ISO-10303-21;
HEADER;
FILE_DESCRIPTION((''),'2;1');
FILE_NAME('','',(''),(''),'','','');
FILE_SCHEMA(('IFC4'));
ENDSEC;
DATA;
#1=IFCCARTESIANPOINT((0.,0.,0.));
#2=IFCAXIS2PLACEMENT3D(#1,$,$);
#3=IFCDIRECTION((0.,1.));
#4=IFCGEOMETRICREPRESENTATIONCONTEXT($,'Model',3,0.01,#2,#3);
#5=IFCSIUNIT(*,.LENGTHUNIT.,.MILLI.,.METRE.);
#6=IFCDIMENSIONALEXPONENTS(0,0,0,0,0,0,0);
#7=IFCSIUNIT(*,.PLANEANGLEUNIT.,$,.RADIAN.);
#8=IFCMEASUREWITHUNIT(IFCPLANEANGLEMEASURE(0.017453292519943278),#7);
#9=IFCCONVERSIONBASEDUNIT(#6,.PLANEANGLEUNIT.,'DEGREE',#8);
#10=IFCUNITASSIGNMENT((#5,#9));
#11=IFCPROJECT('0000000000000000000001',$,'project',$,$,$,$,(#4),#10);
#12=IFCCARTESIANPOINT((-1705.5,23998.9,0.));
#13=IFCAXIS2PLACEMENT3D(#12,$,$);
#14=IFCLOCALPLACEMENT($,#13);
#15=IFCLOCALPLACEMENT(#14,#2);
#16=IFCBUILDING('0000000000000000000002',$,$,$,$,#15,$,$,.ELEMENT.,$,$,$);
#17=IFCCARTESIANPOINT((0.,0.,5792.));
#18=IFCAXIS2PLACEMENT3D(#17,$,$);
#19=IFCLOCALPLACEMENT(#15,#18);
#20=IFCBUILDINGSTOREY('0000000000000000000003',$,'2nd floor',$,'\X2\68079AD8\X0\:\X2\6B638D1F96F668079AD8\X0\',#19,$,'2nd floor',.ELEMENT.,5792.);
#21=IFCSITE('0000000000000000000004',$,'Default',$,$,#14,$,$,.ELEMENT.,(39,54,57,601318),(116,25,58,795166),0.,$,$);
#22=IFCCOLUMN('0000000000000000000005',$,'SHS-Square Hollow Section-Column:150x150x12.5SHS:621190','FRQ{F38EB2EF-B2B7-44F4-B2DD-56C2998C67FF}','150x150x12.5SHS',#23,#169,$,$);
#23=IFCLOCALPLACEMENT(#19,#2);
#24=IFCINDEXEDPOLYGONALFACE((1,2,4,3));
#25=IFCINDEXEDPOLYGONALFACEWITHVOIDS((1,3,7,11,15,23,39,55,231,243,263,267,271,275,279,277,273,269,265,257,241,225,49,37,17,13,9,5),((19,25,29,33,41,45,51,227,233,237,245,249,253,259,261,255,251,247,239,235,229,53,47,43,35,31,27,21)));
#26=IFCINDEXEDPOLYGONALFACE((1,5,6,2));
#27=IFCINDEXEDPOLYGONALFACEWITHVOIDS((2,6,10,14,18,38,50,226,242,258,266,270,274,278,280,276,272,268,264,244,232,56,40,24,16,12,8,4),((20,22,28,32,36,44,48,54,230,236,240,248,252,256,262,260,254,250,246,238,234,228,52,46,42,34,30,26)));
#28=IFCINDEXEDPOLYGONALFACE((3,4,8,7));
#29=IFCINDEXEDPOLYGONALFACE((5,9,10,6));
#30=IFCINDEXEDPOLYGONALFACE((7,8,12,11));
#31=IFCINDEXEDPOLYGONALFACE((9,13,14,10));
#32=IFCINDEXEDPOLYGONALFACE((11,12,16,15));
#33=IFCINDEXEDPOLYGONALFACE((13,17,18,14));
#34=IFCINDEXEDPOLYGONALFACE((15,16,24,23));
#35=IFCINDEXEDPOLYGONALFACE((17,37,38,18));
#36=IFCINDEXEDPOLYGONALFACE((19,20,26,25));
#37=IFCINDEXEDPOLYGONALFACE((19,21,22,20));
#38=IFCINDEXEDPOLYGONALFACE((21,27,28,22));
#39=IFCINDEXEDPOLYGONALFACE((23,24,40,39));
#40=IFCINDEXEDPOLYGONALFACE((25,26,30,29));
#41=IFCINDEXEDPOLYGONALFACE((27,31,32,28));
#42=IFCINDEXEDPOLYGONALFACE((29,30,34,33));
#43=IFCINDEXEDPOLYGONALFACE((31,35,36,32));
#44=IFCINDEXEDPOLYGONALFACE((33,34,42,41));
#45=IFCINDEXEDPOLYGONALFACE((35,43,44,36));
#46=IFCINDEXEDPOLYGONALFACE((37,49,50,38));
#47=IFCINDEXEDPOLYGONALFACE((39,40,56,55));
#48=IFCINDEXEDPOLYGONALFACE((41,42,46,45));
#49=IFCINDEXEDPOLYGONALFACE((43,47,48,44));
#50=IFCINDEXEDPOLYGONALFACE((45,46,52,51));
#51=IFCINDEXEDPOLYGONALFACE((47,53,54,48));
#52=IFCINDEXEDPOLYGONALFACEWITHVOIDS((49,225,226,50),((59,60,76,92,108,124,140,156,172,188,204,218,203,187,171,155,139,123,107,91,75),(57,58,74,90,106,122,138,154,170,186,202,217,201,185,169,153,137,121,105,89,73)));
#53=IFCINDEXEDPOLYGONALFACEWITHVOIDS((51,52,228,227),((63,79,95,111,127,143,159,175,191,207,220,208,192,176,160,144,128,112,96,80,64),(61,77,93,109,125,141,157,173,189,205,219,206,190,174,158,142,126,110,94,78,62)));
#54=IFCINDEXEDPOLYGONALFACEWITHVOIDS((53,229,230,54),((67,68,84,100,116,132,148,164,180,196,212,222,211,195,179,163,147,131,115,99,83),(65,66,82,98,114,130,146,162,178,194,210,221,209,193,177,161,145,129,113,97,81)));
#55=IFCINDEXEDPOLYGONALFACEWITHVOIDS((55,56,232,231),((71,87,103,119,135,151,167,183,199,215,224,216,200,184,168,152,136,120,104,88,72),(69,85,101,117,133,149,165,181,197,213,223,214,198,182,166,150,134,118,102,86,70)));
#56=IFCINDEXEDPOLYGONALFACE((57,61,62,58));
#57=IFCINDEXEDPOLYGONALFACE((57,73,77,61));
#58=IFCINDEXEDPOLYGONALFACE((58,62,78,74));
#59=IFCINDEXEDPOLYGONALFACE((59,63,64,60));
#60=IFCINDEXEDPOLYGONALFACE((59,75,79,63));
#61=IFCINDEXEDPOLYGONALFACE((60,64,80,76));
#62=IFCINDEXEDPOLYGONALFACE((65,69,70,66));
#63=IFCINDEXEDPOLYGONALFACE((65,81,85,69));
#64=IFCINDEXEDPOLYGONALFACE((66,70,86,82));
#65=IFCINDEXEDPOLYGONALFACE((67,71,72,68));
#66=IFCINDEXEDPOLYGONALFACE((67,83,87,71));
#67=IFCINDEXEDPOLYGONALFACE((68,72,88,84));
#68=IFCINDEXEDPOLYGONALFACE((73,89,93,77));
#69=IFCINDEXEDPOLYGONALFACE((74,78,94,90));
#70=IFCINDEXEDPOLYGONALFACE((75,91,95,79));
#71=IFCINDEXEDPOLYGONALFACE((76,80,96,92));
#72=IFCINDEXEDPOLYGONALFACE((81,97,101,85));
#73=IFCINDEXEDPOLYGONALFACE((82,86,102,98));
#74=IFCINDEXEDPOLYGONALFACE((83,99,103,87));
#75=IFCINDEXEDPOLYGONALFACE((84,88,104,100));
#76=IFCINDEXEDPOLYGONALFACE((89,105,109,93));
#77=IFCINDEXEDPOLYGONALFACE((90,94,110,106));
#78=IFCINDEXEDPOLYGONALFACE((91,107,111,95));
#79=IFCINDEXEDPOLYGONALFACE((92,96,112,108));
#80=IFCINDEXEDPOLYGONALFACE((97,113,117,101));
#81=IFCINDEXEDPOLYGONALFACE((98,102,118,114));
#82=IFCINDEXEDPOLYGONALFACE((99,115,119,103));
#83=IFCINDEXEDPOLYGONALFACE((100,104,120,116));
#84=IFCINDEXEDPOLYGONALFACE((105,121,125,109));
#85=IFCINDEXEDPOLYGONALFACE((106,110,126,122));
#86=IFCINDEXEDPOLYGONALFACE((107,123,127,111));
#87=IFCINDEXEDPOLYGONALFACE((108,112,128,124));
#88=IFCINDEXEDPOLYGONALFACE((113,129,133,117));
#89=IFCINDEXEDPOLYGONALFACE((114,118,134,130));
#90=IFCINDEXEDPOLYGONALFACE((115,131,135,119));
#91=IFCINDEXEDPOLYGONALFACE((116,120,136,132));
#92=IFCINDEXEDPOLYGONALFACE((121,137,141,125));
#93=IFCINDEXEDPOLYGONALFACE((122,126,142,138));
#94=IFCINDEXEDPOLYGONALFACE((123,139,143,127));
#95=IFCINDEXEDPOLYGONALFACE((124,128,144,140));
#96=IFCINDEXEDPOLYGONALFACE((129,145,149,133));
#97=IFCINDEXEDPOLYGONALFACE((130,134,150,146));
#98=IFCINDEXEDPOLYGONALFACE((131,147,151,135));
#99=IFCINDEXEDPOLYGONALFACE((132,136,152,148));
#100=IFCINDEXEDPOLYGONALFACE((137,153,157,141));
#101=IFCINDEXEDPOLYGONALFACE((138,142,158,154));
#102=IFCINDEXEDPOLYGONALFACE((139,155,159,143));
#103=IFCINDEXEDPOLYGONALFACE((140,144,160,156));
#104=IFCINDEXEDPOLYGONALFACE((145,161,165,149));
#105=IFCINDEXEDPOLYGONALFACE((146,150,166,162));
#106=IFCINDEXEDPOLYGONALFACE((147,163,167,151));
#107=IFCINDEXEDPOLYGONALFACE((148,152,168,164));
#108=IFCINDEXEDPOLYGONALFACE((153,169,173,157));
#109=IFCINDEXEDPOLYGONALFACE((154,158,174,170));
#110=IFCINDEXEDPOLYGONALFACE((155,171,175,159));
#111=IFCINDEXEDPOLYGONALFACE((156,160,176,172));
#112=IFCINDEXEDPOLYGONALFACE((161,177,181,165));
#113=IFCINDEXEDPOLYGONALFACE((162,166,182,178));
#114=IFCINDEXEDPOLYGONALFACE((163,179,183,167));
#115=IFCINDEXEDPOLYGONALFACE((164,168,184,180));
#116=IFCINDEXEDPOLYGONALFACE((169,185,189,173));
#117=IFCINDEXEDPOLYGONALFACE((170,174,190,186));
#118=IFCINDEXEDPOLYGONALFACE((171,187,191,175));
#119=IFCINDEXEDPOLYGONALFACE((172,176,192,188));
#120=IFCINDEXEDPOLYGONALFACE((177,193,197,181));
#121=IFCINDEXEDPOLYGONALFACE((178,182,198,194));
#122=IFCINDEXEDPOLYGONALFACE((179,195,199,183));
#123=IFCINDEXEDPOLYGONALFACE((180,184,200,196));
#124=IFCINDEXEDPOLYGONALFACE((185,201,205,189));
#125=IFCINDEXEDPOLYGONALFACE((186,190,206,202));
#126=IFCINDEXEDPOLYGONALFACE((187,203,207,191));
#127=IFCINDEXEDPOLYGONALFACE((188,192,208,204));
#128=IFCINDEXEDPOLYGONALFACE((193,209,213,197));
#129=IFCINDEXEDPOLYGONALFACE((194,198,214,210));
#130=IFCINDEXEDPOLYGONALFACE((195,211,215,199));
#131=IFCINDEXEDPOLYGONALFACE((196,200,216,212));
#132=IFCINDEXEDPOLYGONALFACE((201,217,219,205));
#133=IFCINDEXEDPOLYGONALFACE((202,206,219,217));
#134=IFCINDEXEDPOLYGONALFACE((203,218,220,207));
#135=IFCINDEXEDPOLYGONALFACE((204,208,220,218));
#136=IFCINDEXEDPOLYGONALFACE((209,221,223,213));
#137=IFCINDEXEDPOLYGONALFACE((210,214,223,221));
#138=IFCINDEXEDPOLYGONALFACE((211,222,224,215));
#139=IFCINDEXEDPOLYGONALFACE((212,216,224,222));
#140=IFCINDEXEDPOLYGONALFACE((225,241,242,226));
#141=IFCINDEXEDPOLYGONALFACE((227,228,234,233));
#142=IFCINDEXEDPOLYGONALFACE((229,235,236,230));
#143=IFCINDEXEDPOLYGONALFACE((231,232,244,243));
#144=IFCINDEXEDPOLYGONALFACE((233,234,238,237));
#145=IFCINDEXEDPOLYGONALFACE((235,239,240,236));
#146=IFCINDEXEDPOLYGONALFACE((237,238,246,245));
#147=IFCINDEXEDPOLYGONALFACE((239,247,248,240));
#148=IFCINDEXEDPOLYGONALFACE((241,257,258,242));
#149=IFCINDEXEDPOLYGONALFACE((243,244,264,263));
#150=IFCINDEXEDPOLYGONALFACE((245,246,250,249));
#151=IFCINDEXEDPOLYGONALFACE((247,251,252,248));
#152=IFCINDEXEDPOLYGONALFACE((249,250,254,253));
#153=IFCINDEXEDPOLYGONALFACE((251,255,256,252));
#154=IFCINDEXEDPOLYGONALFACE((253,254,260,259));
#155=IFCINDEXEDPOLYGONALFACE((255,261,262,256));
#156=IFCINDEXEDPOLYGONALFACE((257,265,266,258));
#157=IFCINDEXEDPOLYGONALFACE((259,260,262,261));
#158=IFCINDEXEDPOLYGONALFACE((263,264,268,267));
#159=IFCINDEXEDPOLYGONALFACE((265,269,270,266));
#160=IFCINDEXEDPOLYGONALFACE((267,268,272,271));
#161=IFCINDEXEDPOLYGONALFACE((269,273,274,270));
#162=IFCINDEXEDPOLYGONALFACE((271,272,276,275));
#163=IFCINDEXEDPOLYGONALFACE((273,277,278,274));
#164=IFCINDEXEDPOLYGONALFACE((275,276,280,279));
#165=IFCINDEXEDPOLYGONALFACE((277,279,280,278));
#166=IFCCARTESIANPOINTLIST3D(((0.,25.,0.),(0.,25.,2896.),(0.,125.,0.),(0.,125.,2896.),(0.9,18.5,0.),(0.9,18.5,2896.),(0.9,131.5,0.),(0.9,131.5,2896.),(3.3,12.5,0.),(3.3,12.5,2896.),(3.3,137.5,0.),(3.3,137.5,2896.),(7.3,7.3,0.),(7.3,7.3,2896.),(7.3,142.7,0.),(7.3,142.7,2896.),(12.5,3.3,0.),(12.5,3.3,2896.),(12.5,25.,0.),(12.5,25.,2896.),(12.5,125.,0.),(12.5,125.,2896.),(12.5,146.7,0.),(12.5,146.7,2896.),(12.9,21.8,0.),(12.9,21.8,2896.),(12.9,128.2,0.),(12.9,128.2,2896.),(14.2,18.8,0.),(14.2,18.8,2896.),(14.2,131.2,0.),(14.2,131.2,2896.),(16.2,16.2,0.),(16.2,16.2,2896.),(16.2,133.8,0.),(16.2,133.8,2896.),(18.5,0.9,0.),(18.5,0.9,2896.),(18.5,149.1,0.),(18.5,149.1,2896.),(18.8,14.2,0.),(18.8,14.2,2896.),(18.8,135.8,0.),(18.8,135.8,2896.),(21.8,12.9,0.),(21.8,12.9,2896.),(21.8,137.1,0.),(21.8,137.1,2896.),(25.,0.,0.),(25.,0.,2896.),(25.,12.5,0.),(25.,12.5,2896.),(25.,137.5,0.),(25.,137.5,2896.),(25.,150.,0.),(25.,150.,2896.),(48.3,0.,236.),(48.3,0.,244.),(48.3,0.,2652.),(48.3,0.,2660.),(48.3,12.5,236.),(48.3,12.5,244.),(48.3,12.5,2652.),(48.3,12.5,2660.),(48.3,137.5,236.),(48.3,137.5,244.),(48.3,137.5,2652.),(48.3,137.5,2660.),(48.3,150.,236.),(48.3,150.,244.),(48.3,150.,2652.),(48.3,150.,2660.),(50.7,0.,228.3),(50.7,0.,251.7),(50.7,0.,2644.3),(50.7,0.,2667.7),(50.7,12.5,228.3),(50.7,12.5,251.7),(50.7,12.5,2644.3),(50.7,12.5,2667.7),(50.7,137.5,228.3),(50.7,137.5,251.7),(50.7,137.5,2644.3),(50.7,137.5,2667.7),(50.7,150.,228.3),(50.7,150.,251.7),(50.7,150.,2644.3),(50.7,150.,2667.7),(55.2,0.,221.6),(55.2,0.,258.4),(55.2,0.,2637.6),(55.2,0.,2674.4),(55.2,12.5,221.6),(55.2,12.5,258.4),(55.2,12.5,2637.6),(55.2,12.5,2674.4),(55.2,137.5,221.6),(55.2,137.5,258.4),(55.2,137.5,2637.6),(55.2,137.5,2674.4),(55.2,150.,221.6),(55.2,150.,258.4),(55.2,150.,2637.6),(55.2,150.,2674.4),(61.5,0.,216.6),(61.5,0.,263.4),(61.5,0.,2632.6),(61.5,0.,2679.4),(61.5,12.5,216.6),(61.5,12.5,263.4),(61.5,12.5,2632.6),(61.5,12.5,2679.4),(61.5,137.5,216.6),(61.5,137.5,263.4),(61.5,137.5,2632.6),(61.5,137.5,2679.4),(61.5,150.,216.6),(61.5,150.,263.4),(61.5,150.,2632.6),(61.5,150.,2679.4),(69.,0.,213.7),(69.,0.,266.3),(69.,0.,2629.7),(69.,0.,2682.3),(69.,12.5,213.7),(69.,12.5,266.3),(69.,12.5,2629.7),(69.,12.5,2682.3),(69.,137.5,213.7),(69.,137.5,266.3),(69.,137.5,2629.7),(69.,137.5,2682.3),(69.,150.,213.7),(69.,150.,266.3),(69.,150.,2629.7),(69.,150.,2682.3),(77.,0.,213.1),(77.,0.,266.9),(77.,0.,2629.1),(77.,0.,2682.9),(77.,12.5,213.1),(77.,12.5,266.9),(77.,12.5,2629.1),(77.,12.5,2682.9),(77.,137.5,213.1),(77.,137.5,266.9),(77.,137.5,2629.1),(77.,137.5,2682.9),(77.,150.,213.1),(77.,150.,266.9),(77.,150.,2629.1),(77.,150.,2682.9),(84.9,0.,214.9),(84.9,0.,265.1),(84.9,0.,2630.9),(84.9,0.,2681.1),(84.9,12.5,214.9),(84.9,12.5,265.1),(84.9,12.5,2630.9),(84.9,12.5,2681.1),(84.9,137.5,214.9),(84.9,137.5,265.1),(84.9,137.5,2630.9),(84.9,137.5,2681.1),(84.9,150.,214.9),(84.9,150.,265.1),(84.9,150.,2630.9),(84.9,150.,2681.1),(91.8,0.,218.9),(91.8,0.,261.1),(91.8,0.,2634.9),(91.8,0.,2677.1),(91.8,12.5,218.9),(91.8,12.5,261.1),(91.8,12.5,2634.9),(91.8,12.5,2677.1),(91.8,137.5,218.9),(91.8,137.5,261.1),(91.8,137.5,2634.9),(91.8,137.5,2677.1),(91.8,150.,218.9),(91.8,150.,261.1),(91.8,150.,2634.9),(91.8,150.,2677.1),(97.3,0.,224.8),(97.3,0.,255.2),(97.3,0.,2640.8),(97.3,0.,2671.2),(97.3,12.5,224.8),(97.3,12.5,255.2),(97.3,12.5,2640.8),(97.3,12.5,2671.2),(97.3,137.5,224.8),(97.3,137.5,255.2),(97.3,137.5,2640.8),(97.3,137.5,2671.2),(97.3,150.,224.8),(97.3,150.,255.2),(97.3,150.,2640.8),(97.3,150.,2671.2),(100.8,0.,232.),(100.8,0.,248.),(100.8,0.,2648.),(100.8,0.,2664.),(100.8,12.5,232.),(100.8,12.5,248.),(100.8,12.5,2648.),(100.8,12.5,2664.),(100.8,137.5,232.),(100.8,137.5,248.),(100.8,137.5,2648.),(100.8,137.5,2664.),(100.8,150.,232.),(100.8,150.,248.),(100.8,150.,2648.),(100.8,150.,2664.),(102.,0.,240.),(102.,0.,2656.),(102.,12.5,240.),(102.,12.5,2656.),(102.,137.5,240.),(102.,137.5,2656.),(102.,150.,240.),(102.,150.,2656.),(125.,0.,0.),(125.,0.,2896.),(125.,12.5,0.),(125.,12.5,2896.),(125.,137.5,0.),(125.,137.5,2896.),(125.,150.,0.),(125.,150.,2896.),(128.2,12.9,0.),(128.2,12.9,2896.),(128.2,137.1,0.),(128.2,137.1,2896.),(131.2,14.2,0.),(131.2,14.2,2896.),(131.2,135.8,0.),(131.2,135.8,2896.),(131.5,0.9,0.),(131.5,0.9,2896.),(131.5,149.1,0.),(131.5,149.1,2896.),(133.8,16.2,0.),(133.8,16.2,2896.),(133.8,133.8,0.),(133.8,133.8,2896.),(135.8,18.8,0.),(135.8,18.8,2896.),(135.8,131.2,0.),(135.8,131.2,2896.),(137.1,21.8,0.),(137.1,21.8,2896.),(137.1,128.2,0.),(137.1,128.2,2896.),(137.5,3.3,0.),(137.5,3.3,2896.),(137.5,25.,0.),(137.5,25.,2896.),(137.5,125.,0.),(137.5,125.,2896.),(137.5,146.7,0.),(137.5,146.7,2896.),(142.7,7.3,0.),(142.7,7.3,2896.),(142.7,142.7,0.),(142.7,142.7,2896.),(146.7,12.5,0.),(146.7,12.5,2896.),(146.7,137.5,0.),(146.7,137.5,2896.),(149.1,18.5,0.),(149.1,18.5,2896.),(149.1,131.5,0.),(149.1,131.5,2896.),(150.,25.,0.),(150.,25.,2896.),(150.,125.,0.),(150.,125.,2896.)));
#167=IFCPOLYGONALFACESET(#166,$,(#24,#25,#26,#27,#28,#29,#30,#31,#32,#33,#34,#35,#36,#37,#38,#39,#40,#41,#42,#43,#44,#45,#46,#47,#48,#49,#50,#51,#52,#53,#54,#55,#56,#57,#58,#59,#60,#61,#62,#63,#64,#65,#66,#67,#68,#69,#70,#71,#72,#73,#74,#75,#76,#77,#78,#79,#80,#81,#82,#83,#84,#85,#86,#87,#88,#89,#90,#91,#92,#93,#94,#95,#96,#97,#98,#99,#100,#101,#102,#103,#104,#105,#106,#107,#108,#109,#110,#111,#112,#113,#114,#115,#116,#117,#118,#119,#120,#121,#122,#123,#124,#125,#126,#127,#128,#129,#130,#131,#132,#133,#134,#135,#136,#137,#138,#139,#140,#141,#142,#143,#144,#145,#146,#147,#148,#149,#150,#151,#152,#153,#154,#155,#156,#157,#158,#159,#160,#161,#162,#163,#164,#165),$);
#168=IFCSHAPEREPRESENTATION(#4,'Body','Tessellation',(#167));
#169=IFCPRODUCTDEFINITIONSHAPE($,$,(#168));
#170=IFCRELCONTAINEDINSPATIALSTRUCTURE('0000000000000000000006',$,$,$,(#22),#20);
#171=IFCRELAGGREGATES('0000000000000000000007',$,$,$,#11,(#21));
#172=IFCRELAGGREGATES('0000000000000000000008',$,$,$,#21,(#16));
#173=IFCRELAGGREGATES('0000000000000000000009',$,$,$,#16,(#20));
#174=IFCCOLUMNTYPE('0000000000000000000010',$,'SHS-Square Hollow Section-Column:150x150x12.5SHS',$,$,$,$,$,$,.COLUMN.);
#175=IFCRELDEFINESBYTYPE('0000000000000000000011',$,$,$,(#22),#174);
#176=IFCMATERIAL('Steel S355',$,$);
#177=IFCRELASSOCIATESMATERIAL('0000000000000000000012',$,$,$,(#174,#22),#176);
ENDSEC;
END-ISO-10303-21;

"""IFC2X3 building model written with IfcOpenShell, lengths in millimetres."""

from ifc_helpers import new_model, entity, si_unit, converted_unit, direction, frame, frame_2d, origin, origin_2d, place, context, project, spatial, circle_curve, hollow_rectangle, outline, extrude, material, type_object, element, save


model = new_model("IFC2X3")

# Units and contexts
model_context = context("Model", 3, precision=0.01, world=origin(), true_north=direction((0.0, 1.0)))
ifc_project = project(units=[si_unit("LENGTHUNIT", "METRE", prefix="MILLI"), converted_unit("PLANEANGLEUNIT", "DEGREE", entity("IfcPlaneAngleMeasure", 0.017453292519943278), si_unit("PLANEANGLEUNIT", "RADIAN"), dimensions=[0, 0, 0, 0, 0, 0, 0])], contexts=[model_context])

# Site, building, storey
site_placement = place(None, frame((-1705.5, 23998.9, 0.0)))
site = spatial("IfcSite", under=ifc_project, at=site_placement, Name="Default", CompositionType="ELEMENT", RefLatitude=(39, 54, 57, 601318), RefLongitude=(116, 25, 58, 795166), RefElevation=0.0)
building_placement = place(site_placement, origin())
building = spatial("IfcBuilding", under=site, at=building_placement, CompositionType="ELEMENT")
storey_placement = place(building_placement, frame((0.0, 0.0, 5792.0)))
storey = spatial("IfcBuildingStorey", under=building, at=storey_placement, Name="2nd floor", ObjectType="标高:正负零标高", LongName="2nd floor", CompositionType="ELEMENT", Elevation=5792.0)

# Shared definitions
ifc_material_1 = material(Name="Steel S355")

# Column, openings
column_type_1 = type_object("IfcColumnType", Name="SHS-Square Hollow Section-Column:150x150x12.5SHS", PredefinedType="COLUMN", material=ifc_material_1)
column_1_placement = place(storey_placement, frame((75.0, 75.0, 2896.0), z_axis=(0.0, 0.0, 1.0), x_axis=(0.0, -1.0, 0.0)))
column_1 = element("IfcColumn", 1, at=column_1_placement, inside=storey, type_object=column_type_1, material=ifc_material_1, Name="SHS-Square Hollow Section-Column:150x150x12.5SHS:621190", Description="FRQ{F38EB2EF-B2B7-44F4-B2DD-56C2998C67FF}", ObjectType="150x150x12.5SHS", context=model_context, shape_type="SweptSolid", body=[
    extrude(hollow_rectangle(XDim=150.0, YDim=150.0, WallThickness=12.5, InnerFilletRadius=12.5, OuterFilletRadius=25.0, at=origin_2d()), origin(), (0.0, 0.0, -1.0), 2896.0),
])
opening_1_placement = place(column_1_placement, frame((-175.1, 0.0, -2896.0), z_axis=(1.0, 0.0, 0.0), x_axis=(0.0, 1.0, 0.0)))
element("IfcOpeningElement", 2, at=opening_1_placement, cuts=column_1, ObjectType="Opening", context=model_context, shape_type="SweptSolid", body=[
    extrude(outline(circle_curve(frame_2d((0.0, 240.0), x_axis=(1.0, 0.0)), 27.0)), origin(), (0.0, 0.0, 1.0), 350.2),
])
opening_2_placement = place(column_1_placement, frame((-175.1, 0.0, 0.0), z_axis=(1.0, 0.0, 0.0), x_axis=(0.0, 1.0, 0.0)))
element("IfcOpeningElement", 3, at=opening_2_placement, cuts=column_1, ObjectType="Opening", context=model_context, shape_type="SweptSolid", body=[
    extrude(outline(circle_curve(frame_2d((0.0, -240.0), x_axis=(1.0, 0.0)), 27.0)), origin(), (0.0, 0.0, 1.0), 350.2),
])

save(model, "model.ifc")
